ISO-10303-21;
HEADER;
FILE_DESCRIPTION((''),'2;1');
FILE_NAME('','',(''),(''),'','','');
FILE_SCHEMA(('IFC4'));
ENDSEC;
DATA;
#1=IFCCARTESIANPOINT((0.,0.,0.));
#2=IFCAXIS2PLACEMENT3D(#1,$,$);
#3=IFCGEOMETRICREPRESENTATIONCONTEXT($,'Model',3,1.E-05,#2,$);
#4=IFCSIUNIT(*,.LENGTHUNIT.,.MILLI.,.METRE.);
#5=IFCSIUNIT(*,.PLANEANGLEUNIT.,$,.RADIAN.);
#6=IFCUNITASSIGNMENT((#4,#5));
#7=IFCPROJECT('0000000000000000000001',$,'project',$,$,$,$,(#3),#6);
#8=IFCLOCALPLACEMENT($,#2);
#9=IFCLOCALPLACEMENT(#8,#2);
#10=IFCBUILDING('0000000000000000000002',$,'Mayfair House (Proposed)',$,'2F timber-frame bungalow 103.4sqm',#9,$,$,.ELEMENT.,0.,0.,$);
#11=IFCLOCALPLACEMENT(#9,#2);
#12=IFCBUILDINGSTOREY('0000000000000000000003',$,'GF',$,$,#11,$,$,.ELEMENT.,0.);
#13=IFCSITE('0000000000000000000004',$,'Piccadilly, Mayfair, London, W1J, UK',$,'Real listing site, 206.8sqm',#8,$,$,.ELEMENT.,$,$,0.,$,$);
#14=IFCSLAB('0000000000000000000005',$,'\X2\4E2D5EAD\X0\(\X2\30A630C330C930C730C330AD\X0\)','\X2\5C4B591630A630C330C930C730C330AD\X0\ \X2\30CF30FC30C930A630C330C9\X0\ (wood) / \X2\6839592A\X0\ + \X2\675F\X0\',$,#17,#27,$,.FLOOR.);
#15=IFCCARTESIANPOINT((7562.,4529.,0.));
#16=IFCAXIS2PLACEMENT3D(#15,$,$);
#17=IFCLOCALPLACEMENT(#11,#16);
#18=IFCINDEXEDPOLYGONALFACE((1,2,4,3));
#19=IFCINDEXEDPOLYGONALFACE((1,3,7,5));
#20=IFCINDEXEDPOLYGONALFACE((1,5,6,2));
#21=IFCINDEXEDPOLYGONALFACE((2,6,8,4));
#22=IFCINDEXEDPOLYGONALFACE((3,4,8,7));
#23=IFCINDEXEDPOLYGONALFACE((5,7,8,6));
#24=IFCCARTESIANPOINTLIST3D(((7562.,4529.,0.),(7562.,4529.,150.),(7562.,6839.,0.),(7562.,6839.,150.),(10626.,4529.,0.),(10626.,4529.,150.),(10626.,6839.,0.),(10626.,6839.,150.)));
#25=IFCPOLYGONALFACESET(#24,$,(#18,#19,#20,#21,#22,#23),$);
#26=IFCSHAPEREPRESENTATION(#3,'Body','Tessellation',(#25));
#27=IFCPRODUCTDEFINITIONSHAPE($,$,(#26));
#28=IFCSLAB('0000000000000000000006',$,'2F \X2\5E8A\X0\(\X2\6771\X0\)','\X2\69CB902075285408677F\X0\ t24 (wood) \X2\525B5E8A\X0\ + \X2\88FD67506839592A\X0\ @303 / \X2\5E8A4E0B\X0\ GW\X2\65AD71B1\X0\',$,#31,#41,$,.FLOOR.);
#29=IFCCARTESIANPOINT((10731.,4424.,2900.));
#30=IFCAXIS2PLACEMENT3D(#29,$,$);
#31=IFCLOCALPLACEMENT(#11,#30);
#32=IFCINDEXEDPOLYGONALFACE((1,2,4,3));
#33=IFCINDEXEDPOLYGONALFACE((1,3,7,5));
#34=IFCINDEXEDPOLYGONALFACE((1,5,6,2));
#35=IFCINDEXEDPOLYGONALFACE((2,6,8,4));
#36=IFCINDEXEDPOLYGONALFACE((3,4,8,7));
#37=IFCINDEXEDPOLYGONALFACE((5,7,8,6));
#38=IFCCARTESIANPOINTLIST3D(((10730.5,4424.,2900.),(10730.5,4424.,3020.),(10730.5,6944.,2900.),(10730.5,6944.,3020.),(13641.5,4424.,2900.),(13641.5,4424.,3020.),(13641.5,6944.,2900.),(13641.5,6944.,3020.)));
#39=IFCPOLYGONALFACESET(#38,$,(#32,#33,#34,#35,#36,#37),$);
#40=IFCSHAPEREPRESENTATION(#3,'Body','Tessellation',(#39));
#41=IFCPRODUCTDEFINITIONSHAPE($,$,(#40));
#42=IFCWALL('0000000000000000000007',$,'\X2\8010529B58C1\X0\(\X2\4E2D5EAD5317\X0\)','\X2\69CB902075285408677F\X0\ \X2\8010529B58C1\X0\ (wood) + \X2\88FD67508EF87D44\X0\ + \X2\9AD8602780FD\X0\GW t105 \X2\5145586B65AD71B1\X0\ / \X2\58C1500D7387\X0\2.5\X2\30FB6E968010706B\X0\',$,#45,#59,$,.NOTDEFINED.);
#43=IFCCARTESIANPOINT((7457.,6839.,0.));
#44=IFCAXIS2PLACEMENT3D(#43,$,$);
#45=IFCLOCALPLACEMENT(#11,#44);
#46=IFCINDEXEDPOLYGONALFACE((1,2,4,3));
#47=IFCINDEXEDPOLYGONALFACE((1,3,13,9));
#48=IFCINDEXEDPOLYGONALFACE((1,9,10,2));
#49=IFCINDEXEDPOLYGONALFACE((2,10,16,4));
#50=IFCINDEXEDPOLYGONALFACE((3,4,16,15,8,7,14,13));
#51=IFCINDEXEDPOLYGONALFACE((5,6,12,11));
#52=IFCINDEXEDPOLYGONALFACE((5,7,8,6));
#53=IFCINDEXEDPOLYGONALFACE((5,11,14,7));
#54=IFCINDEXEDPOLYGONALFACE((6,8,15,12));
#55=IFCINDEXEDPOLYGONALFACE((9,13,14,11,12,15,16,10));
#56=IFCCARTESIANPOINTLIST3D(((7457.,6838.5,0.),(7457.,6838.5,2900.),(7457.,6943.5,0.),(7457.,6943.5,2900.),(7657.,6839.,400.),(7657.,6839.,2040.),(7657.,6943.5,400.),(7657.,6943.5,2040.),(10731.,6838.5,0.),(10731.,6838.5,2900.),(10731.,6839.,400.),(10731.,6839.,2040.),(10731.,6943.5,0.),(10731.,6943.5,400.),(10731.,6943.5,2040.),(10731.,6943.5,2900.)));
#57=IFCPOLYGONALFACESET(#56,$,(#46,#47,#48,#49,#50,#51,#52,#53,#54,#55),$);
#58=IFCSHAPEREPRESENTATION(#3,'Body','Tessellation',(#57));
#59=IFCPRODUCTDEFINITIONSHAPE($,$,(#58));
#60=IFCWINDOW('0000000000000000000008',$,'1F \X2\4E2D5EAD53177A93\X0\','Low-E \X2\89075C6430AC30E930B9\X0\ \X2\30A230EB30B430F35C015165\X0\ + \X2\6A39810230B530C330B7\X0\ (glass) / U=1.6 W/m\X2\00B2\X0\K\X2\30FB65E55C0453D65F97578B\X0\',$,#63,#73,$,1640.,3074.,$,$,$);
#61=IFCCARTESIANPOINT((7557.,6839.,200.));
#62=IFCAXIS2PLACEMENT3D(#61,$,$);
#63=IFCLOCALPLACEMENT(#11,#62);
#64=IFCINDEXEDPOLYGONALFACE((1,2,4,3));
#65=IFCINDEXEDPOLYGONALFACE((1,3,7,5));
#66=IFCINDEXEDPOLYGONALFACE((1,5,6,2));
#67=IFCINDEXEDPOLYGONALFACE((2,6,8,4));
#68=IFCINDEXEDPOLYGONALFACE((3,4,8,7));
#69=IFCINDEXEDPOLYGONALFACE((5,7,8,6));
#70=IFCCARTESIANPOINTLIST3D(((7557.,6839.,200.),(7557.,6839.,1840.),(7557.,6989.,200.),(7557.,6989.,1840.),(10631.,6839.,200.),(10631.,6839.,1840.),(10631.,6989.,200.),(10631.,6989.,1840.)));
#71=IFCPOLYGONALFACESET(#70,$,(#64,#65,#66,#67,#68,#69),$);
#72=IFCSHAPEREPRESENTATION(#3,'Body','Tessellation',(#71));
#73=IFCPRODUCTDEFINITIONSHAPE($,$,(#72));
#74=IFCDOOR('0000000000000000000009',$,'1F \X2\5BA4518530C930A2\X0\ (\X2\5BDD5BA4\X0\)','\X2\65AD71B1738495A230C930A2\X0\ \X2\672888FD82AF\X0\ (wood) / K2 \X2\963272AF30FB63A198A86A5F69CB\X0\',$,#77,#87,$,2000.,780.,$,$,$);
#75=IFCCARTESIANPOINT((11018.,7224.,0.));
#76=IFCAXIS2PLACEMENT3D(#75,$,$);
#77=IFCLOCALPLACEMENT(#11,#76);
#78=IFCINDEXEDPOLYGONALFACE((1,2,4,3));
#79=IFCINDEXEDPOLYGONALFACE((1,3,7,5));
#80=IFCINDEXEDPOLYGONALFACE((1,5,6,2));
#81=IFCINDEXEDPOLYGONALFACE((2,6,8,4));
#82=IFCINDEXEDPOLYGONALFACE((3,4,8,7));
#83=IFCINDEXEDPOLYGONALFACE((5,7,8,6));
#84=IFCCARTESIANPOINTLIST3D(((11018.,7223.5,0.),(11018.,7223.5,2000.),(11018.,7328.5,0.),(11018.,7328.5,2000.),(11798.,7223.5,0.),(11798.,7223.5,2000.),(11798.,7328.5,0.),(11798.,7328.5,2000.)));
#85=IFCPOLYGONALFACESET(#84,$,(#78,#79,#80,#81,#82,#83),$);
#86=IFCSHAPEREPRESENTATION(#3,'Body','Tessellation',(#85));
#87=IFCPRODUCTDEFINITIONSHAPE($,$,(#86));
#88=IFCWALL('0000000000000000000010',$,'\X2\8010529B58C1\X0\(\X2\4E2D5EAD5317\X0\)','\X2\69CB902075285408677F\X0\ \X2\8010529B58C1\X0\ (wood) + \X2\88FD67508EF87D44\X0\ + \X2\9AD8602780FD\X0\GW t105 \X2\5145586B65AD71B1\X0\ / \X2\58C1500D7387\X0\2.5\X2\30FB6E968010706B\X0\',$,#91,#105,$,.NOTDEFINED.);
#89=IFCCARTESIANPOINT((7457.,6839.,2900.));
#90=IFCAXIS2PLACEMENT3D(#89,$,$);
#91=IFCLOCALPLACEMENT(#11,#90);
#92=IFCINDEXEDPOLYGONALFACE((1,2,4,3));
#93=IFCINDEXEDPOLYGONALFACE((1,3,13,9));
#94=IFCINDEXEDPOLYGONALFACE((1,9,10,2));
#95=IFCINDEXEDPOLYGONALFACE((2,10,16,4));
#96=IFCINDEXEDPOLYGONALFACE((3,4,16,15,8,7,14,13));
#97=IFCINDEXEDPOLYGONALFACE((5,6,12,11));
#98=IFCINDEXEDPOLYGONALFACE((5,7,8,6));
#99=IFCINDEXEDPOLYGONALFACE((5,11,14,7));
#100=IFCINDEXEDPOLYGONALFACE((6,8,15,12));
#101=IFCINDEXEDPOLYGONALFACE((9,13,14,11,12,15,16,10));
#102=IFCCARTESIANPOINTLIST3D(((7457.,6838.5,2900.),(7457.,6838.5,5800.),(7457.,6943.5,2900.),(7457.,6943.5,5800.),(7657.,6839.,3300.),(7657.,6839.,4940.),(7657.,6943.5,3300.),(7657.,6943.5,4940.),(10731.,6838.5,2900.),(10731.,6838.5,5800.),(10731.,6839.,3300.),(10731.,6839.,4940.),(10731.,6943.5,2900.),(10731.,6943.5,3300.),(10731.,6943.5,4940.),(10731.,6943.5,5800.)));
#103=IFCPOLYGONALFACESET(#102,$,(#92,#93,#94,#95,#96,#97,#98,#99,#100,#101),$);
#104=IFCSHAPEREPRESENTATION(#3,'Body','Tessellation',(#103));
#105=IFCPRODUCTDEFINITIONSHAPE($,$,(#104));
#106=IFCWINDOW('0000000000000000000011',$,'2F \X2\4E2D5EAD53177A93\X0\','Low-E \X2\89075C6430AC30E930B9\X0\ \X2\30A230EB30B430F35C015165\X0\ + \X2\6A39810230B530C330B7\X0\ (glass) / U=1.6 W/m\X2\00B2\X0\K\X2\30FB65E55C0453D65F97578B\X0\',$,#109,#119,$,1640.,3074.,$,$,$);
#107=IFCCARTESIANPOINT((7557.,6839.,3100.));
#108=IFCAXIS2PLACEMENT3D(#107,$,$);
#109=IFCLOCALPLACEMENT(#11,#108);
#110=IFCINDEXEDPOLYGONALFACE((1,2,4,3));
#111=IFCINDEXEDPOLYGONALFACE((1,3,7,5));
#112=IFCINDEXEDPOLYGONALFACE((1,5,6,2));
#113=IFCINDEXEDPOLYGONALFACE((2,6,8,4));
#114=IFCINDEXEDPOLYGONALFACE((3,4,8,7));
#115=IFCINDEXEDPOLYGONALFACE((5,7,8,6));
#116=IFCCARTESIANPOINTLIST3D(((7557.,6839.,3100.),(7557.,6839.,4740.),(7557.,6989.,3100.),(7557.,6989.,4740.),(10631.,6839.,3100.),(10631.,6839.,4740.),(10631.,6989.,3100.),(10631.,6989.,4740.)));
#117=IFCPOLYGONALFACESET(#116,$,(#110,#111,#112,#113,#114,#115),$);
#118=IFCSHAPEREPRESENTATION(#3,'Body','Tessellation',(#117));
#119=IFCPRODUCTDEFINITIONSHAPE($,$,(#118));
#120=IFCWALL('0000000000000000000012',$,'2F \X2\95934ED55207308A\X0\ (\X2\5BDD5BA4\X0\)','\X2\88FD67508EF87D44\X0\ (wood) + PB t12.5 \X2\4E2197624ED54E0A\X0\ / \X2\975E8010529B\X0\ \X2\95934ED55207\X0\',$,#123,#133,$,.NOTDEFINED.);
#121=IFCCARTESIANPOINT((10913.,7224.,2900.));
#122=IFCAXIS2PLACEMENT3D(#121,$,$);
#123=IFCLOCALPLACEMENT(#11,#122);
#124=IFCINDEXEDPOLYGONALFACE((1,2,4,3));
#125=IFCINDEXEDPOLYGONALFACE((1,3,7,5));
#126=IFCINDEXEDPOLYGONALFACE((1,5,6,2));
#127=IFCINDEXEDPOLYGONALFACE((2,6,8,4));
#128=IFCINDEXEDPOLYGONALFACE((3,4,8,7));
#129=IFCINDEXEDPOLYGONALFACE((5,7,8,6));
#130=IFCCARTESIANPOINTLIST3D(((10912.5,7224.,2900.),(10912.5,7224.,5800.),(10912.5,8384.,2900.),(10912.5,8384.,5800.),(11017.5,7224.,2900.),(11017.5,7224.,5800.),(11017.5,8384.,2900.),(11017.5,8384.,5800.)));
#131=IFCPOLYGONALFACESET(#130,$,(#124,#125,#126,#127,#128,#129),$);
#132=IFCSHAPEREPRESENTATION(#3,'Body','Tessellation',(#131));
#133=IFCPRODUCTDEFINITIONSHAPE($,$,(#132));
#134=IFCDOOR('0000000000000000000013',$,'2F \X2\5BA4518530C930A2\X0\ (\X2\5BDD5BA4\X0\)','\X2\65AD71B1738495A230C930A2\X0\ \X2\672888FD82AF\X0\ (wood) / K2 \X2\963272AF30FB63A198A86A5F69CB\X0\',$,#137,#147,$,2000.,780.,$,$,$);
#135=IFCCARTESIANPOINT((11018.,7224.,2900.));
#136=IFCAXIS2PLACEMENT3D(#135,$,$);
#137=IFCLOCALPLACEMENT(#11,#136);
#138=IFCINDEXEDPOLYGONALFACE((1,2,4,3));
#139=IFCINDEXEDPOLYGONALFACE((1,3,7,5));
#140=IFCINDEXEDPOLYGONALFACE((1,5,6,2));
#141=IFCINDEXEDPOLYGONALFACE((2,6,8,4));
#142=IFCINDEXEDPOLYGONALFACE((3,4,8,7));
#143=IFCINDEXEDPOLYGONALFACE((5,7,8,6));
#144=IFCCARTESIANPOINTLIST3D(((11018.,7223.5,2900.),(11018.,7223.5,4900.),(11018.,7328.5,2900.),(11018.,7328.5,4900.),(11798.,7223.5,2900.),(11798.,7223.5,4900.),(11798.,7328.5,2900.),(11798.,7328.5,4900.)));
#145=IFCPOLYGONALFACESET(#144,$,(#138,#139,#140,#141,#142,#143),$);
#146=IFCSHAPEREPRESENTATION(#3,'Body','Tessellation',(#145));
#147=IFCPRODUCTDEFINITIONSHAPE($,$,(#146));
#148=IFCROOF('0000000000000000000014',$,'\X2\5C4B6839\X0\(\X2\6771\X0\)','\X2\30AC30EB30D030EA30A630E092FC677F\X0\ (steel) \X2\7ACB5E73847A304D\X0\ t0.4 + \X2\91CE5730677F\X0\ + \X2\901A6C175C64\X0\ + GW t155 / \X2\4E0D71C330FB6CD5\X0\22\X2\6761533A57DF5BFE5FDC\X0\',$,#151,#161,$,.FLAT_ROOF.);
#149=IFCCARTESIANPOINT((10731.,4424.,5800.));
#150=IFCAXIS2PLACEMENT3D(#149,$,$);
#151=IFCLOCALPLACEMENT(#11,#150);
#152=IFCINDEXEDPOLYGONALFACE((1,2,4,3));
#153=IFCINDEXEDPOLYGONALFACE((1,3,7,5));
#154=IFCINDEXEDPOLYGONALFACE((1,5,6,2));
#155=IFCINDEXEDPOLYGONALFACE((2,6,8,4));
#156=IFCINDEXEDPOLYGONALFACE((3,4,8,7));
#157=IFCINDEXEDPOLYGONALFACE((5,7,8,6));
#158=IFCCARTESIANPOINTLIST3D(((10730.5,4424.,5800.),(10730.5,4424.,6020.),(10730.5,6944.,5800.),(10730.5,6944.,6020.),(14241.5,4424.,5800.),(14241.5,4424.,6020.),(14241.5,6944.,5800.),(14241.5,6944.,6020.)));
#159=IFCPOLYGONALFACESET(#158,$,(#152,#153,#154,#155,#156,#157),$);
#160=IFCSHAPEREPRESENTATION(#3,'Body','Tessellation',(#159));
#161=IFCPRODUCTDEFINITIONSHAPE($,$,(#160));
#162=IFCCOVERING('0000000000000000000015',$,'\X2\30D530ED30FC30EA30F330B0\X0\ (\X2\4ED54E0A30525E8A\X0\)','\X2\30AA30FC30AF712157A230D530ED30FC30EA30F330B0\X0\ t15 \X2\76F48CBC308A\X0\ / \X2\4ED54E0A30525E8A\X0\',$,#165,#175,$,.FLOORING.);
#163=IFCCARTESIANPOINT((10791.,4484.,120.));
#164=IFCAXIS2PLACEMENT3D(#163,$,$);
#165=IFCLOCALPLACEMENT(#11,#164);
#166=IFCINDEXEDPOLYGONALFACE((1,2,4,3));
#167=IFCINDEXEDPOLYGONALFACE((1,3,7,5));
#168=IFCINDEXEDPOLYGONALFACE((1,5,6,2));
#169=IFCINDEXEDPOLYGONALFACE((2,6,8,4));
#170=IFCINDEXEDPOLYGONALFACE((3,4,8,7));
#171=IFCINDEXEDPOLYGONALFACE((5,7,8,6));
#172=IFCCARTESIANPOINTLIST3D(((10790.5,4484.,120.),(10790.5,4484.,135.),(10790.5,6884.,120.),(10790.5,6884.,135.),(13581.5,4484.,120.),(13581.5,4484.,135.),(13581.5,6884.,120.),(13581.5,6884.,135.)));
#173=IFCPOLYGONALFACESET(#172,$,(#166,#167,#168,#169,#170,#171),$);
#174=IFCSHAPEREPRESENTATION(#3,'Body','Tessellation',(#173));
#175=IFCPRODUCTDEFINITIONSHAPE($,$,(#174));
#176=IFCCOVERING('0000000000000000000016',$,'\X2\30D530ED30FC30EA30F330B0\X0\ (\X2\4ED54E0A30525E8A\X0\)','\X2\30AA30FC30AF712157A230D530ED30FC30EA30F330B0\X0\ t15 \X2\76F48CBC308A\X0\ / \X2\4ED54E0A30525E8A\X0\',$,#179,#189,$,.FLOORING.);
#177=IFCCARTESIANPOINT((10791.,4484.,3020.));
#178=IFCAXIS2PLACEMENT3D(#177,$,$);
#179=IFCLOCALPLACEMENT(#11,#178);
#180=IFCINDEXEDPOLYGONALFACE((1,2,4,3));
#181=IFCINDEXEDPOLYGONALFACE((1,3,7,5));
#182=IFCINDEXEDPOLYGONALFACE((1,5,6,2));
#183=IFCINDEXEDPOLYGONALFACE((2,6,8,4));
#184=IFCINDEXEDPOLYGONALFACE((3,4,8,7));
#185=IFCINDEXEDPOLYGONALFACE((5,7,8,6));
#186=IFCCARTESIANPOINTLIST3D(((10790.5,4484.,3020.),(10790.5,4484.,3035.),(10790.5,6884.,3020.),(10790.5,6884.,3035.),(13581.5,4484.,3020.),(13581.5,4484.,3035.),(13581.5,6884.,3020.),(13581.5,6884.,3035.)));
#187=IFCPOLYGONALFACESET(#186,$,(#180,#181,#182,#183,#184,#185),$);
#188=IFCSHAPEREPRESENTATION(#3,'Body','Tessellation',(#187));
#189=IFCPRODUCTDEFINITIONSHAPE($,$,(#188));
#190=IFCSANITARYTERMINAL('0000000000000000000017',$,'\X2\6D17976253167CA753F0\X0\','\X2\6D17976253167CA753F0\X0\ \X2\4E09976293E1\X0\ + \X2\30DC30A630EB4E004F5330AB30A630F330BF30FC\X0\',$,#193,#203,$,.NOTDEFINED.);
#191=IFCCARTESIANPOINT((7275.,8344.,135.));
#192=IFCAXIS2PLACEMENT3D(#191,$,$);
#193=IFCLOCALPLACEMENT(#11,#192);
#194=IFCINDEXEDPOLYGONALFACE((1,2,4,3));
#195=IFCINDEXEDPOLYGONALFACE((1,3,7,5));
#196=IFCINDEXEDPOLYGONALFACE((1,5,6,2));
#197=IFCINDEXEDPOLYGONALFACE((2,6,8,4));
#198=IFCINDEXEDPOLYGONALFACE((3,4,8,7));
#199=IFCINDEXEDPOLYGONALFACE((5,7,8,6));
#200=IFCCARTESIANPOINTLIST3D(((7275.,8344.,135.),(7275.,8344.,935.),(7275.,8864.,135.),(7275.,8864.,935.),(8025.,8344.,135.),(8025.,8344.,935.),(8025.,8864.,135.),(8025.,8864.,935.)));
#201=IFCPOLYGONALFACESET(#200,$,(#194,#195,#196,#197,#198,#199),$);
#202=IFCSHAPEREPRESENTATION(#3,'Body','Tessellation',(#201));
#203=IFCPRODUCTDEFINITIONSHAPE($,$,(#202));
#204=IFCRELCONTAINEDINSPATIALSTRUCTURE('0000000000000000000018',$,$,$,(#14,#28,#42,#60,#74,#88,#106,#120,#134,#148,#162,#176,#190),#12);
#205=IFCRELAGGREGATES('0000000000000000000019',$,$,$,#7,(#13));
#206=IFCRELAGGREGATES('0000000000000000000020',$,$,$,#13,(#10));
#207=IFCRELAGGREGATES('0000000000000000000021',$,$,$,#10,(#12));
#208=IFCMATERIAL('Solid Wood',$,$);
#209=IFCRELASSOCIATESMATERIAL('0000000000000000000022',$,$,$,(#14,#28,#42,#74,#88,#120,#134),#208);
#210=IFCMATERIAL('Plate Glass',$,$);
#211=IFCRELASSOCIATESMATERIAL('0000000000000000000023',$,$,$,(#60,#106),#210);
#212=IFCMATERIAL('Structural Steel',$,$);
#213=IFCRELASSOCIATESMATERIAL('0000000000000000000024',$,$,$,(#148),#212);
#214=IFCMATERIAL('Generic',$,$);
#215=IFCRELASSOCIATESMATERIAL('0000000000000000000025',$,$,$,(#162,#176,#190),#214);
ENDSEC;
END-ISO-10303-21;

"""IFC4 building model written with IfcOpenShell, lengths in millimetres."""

from ifc_helpers import new_model, si_unit, frame, frame_2d, origin, place, context, project, spatial, rectangle, extrude, material, element, fill, save


model = new_model("IFC4")

# Units and contexts
model_context = context("Model", 3, precision=1e-05, world=origin())
ifc_project = project(units=[si_unit("LENGTHUNIT", "METRE", prefix="MILLI"), si_unit("PLANEANGLEUNIT", "RADIAN")], contexts=[model_context])

# Site, building, storey
site_placement = place(None, origin())
site = spatial("IfcSite", under=ifc_project, at=site_placement, Name="Piccadilly, Mayfair, London, W1J, UK", ObjectType="Real listing site, 206.8sqm", CompositionType="ELEMENT", RefElevation=0.0)
building_placement = place(site_placement, origin())
building = spatial("IfcBuilding", under=site, at=building_placement, Name="Mayfair House (Proposed)", ObjectType="2F timber-frame bungalow 103.4sqm", CompositionType="ELEMENT", ElevationOfRefHeight=0.0, ElevationOfTerrain=0.0)
storey_placement = place(building_placement, origin())
storey = spatial("IfcBuildingStorey", under=building, at=storey_placement, Name="GF", CompositionType="ELEMENT", Elevation=0.0)

# Slabs
ifc_material_1 = material(Name="Solid Wood")
slab_1_placement = place(storey_placement, frame((7562.0, 4529.0, 0.0)))
element("IfcSlab", 1, at=slab_1_placement, inside=storey, material=ifc_material_1, Name="中庭(ウッドデッキ)", Description="屋外ウッドデッキ ハードウッド (wood) / 根太 + 束", PredefinedType="FLOOR", context=model_context, shape_type="SweptSolid", body=[
    extrude(rectangle(XDim=3064.0, YDim=2310.0, at=frame_2d((1532.0, 1155.0))), frame((7562.0, 4529.0, 0.0)), (0.0, 0.0, 1.0), 150.0),
])
slab_2_placement = place(storey_placement, frame((10731.0, 4424.0, 2900.0)))
element("IfcSlab", 2, at=slab_2_placement, inside=storey, material=ifc_material_1, Name="2F 床(東)", Description="構造用合板 t24 (wood) 剛床 + 製材根太 @303 / 床下 GW断熱", PredefinedType="FLOOR", context=model_context, shape_type="SweptSolid", body=[
    extrude(rectangle(XDim=2911.0, YDim=2520.0, at=frame_2d((1455.0, 1260.0))), frame((10731.0, 4424.0, 2900.0)), (0.0, 0.0, 1.0), 120.0),
])

# Wall, opening, window
wall_1_placement = place(storey_placement, frame((7457.0, 6839.0, 0.0)))
wall_1 = element("IfcWall", 3, at=wall_1_placement, inside=storey, material=ifc_material_1, Name="耐力壁(中庭北)", Description="構造用合板 耐力壁 (wood) + 製材軸組 + 高性能GW t105 充填断熱 / 壁倍率2.5・準耐火", PredefinedType="NOTDEFINED", context=model_context, shape_type="SweptSolid", body=[
    extrude(rectangle(XDim=3274.0, YDim=105.0, at=frame_2d((1637.0, 52.0))), frame((7457.0, 6839.0, 0.0)), (0.0, 0.0, 1.0), 2900.0),
])
opening_1_placement = place(storey_placement, frame((7557.0, 6839.0, 200.0)))
opening_1 = element("IfcOpeningElement", 4, at=opening_1_placement, cuts=wall_1, PredefinedType="NOTDEFINED", context=model_context, shape_type="SweptSolid", body=[
    extrude(rectangle(XDim=3074.0, YDim=150.0, at=frame_2d((1537.0, 75.0))), frame((7557.0, 6839.0, 200.0)), (0.0, 0.0, 1.0), 1640.0),
])
ifc_material_2 = material(Name="Plate Glass")
window_1_placement = place(storey_placement, frame((7557.0, 6839.0, 200.0)))
window_1 = element("IfcWindow", 5, at=window_1_placement, inside=storey, material=ifc_material_2, Name="1F 中庭北窓", Description="Low-E 複層ガラス アルゴン封入 + 樹脂サッシ (glass) / U=1.6 W/m²K・日射取得型", OverallHeight=1640.0, OverallWidth=3074.0, context=model_context, shape_type="SweptSolid", body=[
    extrude(rectangle(XDim=3074.0, YDim=150.0, at=frame_2d((1537.0, 75.0))), frame((7557.0, 6839.0, 200.0)), (0.0, 0.0, 1.0), 1640.0),
])
fill(opening_1, window_1)

# Door
door_1_placement = place(storey_placement, frame((11018.0, 7224.0, 0.0)))
element("IfcDoor", 6, at=door_1_placement, inside=storey, material=ifc_material_1, Name="1F 室内ドア (寝室)", Description="断熱玄関ドア 木製芯 (wood) / K2 防犯・採風機構", OverallHeight=2000.0, OverallWidth=780.0, context=model_context, shape_type="SweptSolid", body=[
    extrude(rectangle(XDim=780.0, YDim=105.0, at=frame_2d((390.0, 52.0))), frame((11018.0, 7224.0, 0.0)), (0.0, 0.0, 1.0), 2000.0),
])

# Wall, opening, window
wall_2_placement = place(storey_placement, frame((7457.0, 6839.0, 2900.0)))
wall_2 = element("IfcWall", 7, at=wall_2_placement, inside=storey, material=ifc_material_1, Name="耐力壁(中庭北)", Description="構造用合板 耐力壁 (wood) + 製材軸組 + 高性能GW t105 充填断熱 / 壁倍率2.5・準耐火", PredefinedType="NOTDEFINED", context=model_context, shape_type="SweptSolid", body=[
    extrude(rectangle(XDim=3274.0, YDim=105.0, at=frame_2d((1637.0, 52.0))), frame((7457.0, 6839.0, 2900.0)), (0.0, 0.0, 1.0), 2900.0),
])
opening_2_placement = place(storey_placement, frame((7557.0, 6839.0, 3100.0)))
opening_2 = element("IfcOpeningElement", 8, at=opening_2_placement, cuts=wall_2, PredefinedType="NOTDEFINED", context=model_context, shape_type="SweptSolid", body=[
    extrude(rectangle(XDim=3074.0, YDim=150.0, at=frame_2d((1537.0, 75.0))), frame((7557.0, 6839.0, 3100.0)), (0.0, 0.0, 1.0), 1640.0),
])
window_2_placement = place(storey_placement, frame((7557.0, 6839.0, 3100.0)))
window_2 = element("IfcWindow", 9, at=window_2_placement, inside=storey, material=ifc_material_2, Name="2F 中庭北窓", Description="Low-E 複層ガラス アルゴン封入 + 樹脂サッシ (glass) / U=1.6 W/m²K・日射取得型", OverallHeight=1640.0, OverallWidth=3074.0, context=model_context, shape_type="SweptSolid", body=[
    extrude(rectangle(XDim=3074.0, YDim=150.0, at=frame_2d((1537.0, 75.0))), frame((7557.0, 6839.0, 3100.0)), (0.0, 0.0, 1.0), 1640.0),
])
fill(opening_2, window_2)

# Wall
wall_3_placement = place(storey_placement, frame((10913.0, 7224.0, 2900.0)))
element("IfcWall", 10, at=wall_3_placement, inside=storey, material=ifc_material_1, Name="2F 間仕切り (寝室)", Description="製材軸組 (wood) + PB t12.5 両面仕上 / 非耐力 間仕切", PredefinedType="NOTDEFINED", context=model_context, shape_type="SweptSolid", body=[
    extrude(rectangle(XDim=105.0, YDim=1160.0, at=frame_2d((52.0, 580.0))), frame((10913.0, 7224.0, 2900.0)), (0.0, 0.0, 1.0), 2900.0),
])

# Door
door_2_placement = place(storey_placement, frame((11018.0, 7224.0, 2900.0)))
element("IfcDoor", 11, at=door_2_placement, inside=storey, material=ifc_material_1, Name="2F 室内ドア (寝室)", Description="断熱玄関ドア 木製芯 (wood) / K2 防犯・採風機構", OverallHeight=2000.0, OverallWidth=780.0, context=model_context, shape_type="SweptSolid", body=[
    extrude(rectangle(XDim=780.0, YDim=105.0, at=frame_2d((390.0, 52.0))), frame((11018.0, 7224.0, 2900.0)), (0.0, 0.0, 1.0), 2000.0),
])

# Roof
ifc_material_3 = material(Name="Structural Steel")
for number, where, name in (
    (12, (10731.0, 4424.0, 5800.0), "屋根(東)"),
):
    element("IfcRoof", number, at=place(storey_placement, frame(where)), inside=storey, material=ifc_material_3, Name=name, Description="ガルバリウム鋼板 (steel) 立平葺き t0.4 + 野地板 + 通気層 + GW t155 / 不燃・法22条区域対応", PredefinedType="FLAT_ROOF", context=model_context, shape_type="SweptSolid", body=[
        extrude(rectangle(XDim=3511.0, YDim=2520.0, at=frame_2d((1755.0, 1260.0))), frame((10731.0, 4424.0, 5800.0)), (0.0, 0.0, 1.0), 220.0),
    ])

# Coverings
ifc_material_4 = material(Name="Generic")
covering_1_placement = place(storey_placement, frame((10791.0, 4484.0, 120.0)))
element("IfcCovering", 13, at=covering_1_placement, inside=storey, material=ifc_material_4, Name="フローリング (仕上げ床)", Description="オーク無垢フローリング t15 直貼り / 仕上げ床", PredefinedType="FLOORING", context=model_context, shape_type="SweptSolid", body=[
    extrude(rectangle(XDim=2791.0, YDim=2400.0, at=frame_2d((1395.0, 1200.0))), frame((10791.0, 4484.0, 120.0)), (0.0, 0.0, 1.0), 15.0),
])
covering_2_placement = place(storey_placement, frame((10791.0, 4484.0, 3020.0)))
element("IfcCovering", 14, at=covering_2_placement, inside=storey, material=ifc_material_4, Name="フローリング (仕上げ床)", Description="オーク無垢フローリング t15 直貼り / 仕上げ床", PredefinedType="FLOORING", context=model_context, shape_type="SweptSolid", body=[
    extrude(rectangle(XDim=2791.0, YDim=2400.0, at=frame_2d((1395.0, 1200.0))), frame((10791.0, 4484.0, 3020.0)), (0.0, 0.0, 1.0), 15.0),
])

# Sanitary terminal
sanitary_terminal_1_placement = place(storey_placement, frame((7275.0, 8344.0, 135.0)))
element("IfcSanitaryTerminal", 15, at=sanitary_terminal_1_placement, inside=storey, material=ifc_material_4, Name="洗面化粧台", Description="洗面化粧台 三面鏡 + ボウル一体カウンター", PredefinedType="NOTDEFINED", context=model_context, shape_type="SweptSolid", body=[
    extrude(rectangle(XDim=750.0, YDim=520.0, at=frame_2d((375.0, 260.0))), frame((7275.0, 8344.0, 135.0)), (0.0, 0.0, 1.0), 800.0),
])

save(model, "model.ifc")
